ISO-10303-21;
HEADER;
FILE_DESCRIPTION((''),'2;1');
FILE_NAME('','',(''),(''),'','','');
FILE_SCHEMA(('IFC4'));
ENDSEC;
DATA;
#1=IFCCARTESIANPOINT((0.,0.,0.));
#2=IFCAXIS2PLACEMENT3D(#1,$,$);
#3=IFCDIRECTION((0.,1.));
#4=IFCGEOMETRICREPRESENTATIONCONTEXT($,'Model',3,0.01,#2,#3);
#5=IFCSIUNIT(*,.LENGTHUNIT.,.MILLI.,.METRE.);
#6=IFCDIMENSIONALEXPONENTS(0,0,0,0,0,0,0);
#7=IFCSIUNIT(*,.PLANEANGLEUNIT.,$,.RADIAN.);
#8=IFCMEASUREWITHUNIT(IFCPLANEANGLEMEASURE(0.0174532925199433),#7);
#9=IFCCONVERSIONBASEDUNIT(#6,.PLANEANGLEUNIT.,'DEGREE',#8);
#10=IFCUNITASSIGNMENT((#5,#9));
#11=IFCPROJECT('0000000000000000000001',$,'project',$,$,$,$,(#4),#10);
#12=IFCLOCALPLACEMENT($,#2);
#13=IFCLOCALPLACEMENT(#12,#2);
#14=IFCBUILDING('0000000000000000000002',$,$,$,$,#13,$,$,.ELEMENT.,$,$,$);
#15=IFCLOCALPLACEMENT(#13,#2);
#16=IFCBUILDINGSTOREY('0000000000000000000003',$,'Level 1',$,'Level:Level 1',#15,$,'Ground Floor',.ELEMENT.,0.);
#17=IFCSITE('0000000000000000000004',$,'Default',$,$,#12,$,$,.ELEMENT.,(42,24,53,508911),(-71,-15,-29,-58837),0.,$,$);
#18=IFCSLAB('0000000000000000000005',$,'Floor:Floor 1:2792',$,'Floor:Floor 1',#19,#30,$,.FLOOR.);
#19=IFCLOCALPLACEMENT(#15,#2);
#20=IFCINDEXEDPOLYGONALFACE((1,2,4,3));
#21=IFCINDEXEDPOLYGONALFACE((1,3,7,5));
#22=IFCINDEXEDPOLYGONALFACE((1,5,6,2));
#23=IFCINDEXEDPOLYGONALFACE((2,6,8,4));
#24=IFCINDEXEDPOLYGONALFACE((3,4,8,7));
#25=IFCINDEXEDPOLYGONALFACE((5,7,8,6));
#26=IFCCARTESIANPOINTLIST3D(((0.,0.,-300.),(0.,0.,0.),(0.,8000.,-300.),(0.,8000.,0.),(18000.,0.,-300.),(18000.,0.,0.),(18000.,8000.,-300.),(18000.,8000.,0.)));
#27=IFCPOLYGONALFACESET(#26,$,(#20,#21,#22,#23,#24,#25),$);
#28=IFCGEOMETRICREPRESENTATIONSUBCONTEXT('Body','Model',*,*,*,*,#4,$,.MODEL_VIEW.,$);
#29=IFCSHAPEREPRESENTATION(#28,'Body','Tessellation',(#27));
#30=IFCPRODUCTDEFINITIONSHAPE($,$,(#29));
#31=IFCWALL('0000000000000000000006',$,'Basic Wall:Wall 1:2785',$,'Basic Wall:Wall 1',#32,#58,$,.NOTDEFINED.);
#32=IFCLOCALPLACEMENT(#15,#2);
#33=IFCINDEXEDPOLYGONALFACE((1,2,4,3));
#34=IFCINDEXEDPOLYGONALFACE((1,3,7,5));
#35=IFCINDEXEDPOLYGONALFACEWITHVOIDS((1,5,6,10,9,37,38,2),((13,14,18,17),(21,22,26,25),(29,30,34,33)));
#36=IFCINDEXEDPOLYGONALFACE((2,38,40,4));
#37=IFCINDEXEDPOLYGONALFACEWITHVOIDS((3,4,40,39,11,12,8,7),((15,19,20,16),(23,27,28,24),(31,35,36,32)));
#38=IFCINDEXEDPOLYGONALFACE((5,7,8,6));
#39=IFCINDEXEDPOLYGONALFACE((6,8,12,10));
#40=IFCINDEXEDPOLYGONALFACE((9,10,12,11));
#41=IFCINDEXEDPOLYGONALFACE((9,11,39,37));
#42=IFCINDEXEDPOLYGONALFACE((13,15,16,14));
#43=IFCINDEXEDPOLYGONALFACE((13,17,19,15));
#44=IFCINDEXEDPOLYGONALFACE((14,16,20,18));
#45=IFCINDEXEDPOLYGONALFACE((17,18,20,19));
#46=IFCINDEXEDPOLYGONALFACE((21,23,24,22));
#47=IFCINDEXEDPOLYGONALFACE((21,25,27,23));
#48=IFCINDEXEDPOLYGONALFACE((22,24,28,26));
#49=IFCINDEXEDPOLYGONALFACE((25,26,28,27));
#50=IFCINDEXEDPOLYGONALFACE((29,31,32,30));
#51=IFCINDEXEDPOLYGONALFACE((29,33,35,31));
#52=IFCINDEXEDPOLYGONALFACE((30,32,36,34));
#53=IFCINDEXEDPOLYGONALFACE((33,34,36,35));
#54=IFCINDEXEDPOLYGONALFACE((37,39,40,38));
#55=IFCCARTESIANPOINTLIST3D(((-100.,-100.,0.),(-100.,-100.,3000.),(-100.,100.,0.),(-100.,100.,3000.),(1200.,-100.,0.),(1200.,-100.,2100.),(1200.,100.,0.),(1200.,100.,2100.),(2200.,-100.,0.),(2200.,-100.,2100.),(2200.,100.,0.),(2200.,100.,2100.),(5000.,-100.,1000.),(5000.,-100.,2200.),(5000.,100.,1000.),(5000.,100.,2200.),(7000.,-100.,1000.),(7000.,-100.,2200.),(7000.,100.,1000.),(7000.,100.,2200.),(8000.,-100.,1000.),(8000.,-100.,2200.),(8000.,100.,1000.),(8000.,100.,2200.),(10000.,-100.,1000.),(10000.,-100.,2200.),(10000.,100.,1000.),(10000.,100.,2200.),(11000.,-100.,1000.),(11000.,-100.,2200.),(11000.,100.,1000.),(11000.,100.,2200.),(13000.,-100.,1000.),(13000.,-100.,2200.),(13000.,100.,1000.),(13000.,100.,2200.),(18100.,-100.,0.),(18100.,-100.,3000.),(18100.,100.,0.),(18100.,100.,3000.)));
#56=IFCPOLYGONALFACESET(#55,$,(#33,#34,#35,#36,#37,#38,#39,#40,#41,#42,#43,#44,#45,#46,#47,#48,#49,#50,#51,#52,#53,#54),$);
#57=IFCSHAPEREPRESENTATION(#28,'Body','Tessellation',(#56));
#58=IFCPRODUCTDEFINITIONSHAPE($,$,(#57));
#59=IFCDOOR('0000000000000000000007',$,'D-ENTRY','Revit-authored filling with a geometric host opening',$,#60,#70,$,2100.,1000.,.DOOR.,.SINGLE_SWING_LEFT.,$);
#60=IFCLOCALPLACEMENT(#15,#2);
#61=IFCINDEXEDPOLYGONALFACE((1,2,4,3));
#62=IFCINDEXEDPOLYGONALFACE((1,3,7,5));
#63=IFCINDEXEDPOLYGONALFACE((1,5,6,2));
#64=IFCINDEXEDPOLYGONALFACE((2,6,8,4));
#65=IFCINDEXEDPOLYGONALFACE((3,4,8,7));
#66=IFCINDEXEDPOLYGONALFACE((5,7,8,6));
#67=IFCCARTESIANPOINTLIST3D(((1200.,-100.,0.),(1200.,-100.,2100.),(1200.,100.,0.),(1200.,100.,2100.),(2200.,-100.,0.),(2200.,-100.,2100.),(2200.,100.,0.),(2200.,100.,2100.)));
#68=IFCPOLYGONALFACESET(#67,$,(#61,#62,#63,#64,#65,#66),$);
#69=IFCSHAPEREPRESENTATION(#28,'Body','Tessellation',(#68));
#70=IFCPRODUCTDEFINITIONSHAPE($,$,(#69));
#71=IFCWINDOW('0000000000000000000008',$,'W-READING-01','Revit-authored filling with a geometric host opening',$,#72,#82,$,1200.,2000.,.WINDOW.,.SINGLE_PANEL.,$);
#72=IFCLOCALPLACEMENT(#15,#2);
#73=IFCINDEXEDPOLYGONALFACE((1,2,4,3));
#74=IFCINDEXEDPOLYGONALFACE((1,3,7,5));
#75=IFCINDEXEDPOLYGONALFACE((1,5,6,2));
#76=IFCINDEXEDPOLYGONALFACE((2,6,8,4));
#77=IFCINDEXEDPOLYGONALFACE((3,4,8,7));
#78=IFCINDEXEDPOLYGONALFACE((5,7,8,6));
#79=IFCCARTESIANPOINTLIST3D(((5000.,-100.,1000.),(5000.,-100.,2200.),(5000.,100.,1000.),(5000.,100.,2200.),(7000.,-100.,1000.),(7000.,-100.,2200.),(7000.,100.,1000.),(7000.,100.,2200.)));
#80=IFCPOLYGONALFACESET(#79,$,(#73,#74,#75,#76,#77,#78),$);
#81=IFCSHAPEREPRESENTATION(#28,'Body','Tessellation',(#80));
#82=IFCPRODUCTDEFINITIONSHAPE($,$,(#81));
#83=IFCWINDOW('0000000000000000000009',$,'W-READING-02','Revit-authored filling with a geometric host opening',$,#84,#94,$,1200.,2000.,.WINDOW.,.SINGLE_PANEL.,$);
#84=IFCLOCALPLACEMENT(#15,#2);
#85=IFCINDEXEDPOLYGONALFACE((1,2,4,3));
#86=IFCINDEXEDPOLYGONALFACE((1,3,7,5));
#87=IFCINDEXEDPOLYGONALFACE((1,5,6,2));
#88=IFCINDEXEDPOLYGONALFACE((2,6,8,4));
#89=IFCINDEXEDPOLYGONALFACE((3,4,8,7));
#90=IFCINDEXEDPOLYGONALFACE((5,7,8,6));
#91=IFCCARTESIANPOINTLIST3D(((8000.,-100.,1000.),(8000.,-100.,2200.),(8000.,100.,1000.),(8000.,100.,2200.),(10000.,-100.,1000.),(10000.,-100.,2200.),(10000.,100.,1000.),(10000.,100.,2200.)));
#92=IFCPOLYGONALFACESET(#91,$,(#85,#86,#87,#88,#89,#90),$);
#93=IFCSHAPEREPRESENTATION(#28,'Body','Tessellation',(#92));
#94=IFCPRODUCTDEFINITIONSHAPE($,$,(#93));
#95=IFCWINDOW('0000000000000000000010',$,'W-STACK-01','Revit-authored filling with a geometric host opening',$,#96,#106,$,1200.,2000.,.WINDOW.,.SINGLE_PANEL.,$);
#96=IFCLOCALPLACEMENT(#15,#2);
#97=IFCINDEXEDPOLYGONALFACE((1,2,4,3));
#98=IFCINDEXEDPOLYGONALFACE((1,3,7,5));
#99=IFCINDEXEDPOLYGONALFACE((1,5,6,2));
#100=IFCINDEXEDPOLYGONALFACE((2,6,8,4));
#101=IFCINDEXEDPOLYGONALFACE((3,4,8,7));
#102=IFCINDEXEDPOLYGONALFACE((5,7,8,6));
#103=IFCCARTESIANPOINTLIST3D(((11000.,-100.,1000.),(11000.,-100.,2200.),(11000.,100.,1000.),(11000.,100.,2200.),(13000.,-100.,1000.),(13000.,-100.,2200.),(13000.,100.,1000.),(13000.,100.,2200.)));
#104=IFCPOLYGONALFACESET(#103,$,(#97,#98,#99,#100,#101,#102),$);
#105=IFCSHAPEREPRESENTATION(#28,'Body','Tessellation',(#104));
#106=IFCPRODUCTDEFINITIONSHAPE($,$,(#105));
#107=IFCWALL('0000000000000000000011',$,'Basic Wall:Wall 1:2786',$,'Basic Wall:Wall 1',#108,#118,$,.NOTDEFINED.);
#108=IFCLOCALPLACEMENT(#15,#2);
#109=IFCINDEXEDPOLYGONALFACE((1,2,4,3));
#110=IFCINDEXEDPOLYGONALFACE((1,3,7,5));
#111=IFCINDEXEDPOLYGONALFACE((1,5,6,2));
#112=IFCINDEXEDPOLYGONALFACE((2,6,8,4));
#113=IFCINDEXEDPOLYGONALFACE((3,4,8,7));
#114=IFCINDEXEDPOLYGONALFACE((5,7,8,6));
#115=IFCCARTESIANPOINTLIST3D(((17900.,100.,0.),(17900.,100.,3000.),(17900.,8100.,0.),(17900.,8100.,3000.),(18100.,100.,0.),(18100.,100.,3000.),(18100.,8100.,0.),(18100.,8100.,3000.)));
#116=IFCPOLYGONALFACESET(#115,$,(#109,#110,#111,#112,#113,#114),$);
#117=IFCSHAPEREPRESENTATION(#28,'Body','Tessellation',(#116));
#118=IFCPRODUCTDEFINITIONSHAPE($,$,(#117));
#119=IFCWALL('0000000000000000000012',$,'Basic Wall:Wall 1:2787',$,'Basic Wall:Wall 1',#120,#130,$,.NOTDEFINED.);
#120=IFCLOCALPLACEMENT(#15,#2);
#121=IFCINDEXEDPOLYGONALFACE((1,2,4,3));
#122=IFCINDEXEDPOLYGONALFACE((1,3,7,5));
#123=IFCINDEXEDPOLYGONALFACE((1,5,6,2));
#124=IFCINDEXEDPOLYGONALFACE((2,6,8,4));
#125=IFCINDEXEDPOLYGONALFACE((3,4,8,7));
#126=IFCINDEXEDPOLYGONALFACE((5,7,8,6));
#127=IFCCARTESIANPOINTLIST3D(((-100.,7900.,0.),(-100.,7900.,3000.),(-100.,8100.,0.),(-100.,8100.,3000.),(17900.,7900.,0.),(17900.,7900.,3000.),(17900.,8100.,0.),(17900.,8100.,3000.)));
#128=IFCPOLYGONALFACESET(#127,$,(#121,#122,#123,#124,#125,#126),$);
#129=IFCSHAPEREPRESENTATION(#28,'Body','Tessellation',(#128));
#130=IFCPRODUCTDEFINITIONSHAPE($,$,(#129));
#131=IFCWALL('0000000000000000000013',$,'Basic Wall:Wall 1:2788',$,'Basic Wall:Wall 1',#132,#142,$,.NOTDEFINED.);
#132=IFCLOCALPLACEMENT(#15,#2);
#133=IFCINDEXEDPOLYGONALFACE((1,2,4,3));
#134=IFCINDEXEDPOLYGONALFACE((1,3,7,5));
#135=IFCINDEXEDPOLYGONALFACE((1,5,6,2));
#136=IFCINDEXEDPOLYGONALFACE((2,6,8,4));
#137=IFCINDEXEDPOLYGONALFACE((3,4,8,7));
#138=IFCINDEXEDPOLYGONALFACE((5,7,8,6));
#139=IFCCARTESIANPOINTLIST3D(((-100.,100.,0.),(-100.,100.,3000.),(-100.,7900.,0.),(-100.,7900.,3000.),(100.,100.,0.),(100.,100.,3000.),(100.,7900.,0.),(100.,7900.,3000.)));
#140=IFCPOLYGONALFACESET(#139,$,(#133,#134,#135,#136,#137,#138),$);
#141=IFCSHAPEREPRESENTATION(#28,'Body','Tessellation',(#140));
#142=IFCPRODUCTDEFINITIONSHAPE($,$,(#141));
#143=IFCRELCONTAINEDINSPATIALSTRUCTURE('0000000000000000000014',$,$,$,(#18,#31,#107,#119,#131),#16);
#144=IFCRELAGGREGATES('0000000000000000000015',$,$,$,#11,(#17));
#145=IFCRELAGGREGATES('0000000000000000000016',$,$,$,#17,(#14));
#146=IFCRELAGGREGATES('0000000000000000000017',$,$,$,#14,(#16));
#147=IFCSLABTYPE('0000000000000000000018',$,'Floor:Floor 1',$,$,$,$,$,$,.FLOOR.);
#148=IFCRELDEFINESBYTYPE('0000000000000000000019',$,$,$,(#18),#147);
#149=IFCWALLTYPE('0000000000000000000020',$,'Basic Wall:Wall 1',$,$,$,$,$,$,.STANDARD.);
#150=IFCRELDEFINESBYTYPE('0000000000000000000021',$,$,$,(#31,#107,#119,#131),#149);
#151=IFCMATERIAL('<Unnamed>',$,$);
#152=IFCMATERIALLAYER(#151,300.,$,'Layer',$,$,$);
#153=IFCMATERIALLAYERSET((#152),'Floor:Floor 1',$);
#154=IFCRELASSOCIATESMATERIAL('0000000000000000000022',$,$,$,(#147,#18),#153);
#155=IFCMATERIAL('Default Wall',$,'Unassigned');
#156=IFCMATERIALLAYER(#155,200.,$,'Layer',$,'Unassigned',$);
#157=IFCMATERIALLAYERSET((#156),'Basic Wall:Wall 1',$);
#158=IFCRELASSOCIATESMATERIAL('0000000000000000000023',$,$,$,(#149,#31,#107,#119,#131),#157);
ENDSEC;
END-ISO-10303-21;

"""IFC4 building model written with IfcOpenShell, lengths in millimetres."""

from ifc_helpers import new_model, entity, si_unit, converted_unit, direction, frame, frame_2d, origin, origin_2d, origin_2d_with_axis, place, context, subcontext, project, spatial, rectangle, extrude, material, layer, layer_set, layer_usage, type_object, element, fill, save


model = new_model("IFC4")

# Units and contexts
model_context = context("Model", 3, precision=0.01, world=origin(), true_north=direction((0.0, 1.0)))
body_context = subcontext(model_context, "Body", "Model", "MODEL_VIEW")
ifc_project = project(units=[si_unit("LENGTHUNIT", "METRE", prefix="MILLI"), converted_unit("PLANEANGLEUNIT", "DEGREE", entity("IfcPlaneAngleMeasure", 0.0174532925199433), si_unit("PLANEANGLEUNIT", "RADIAN"), dimensions=[0, 0, 0, 0, 0, 0, 0])], contexts=[model_context])

# Site, building, storey
site_placement = place(None, origin())
site = spatial("IfcSite", under=ifc_project, at=site_placement, Name="Default", CompositionType="ELEMENT", RefLatitude=(42, 24, 53, 508911), RefLongitude=(-71, -15, -29, -58837), RefElevation=0.0)
building_placement = place(site_placement, origin())
building = spatial("IfcBuilding", under=site, at=building_placement, CompositionType="ELEMENT")
storey_placement = place(building_placement, origin())
storey = spatial("IfcBuildingStorey", under=building, at=storey_placement, Name="Level 1", ObjectType="Level:Level 1", LongName="Ground Floor", CompositionType="ELEMENT", Elevation=0.0)

# Slab
ifc_material_1 = material(Name="<Unnamed>")
ifc_layer_1 = layer(ifc_material_1, 300.0, Name="Layer")
ifc_layer_set_1 = layer_set([ifc_layer_1], Name="Floor:Floor 1")
ifc_layer_usage_1 = layer_usage(ifc_layer_set_1, "AXIS3", "POSITIVE", 0.0)
slab_type = type_object("IfcSlabType", Name="Floor:Floor 1", PredefinedType="FLOOR", material=ifc_layer_set_1)
slab_placement = place(storey_placement, origin())
element("IfcSlab", 1, at=slab_placement, inside=storey, type_object=slab_type, material=ifc_layer_usage_1, Name="Floor:Floor 1:2792", ObjectType="Floor:Floor 1", PredefinedType="FLOOR", context=body_context, shape_type="SweptSolid", body=[
    extrude(rectangle(XDim=8000.0, YDim=18000.0, at=origin_2d_with_axis()), frame((9000.0, 4000.0, 0.0), z_axis=(0.0, 0.0, -1.0), x_axis=(0.0, 1.0, 0.0)), (0.0, 0.0, 1.0), 300.0),
])

# Wall, openings, door, windows
ifc_material_2 = material(Name="Default Wall", Category="Unassigned")
ifc_layer_2 = layer(ifc_material_2, 200.0, Name="Layer", Category="Unassigned")
ifc_layer_set_2 = layer_set([ifc_layer_2], Name="Basic Wall:Wall 1")
ifc_layer_usage_2 = layer_usage(ifc_layer_set_2, "AXIS2", "NEGATIVE", 100.0)
wall_type = type_object("IfcWallType", Name="Basic Wall:Wall 1", PredefinedType="STANDARD", material=ifc_layer_set_2)
wall_1_placement = place(storey_placement, frame((-100.0, 0.0, 0.0)))
wall_1 = element("IfcWall", 2, at=wall_1_placement, inside=storey, type_object=wall_type, material=ifc_layer_usage_2, Name="Basic Wall:Wall 1:2785", ObjectType="Basic Wall:Wall 1", PredefinedType="NOTDEFINED", context=body_context, shape_type="SweptSolid", body=[
    extrude(rectangle(XDim=18200.0, YDim=200.0, at=frame_2d((9100.0, 0.0), x_axis=(-1.0, 0.0))), origin(), (0.0, 0.0, 1.0), 3000.0),
])
opening_1_placement = place(storey_placement, frame((1200.0, -100.0, 0.0)))
opening_1 = element("IfcOpeningElement", 3, at=opening_1_placement, cuts=wall_1, PredefinedType="OPENING", context=body_context, shape_type="SweptSolid", body=[
    extrude(rectangle(XDim=1000.0, YDim=200.0, at=origin_2d()), frame((500.0, 100.0, 0.0)), (0.0, 0.0, 1.0), 2100.0),
])
opening_2_placement = place(storey_placement, frame((5000.0, -100.0, 1000.0)))
opening_2 = element("IfcOpeningElement", 4, at=opening_2_placement, cuts=wall_1, PredefinedType="OPENING", context=body_context, shape_type="SweptSolid", body=[
    extrude(rectangle(XDim=2000.0, YDim=200.0, at=origin_2d()), frame((1000.0, 100.0, 0.0)), (0.0, 0.0, 1.0), 1200.0),
])
opening_3_placement = place(storey_placement, frame((8000.0, -100.0, 1000.0)))
opening_3 = element("IfcOpeningElement", 5, at=opening_3_placement, cuts=wall_1, PredefinedType="OPENING", context=body_context, shape_type="SweptSolid", body=[
    extrude(rectangle(XDim=2000.0, YDim=200.0, at=origin_2d()), frame((1000.0, 100.0, 0.0)), (0.0, 0.0, 1.0), 1200.0),
])
opening_4_placement = place(storey_placement, frame((11000.0, -100.0, 1000.0)))
opening_4 = element("IfcOpeningElement", 6, at=opening_4_placement, cuts=wall_1, PredefinedType="OPENING", context=body_context, shape_type="SweptSolid", body=[
    extrude(rectangle(XDim=2000.0, YDim=200.0, at=origin_2d()), frame((1000.0, 100.0, 0.0)), (0.0, 0.0, 1.0), 1200.0),
])
door_1_placement = place(storey_placement, frame((1200.0, -100.0, 0.0)))
door_1 = element("IfcDoor", 7, at=door_1_placement, Name="D-ENTRY", Description="Revit-authored filling with a geometric host opening", OperationType="SINGLE_SWING_LEFT", OverallHeight=2100.0, OverallWidth=1000.0, PredefinedType="DOOR", context=body_context, shape_type="SweptSolid", body=[
    extrude(rectangle(XDim=1000.0, YDim=200.0, at=origin_2d()), frame((500.0, 100.0, 0.0)), (0.0, 0.0, 1.0), 2100.0),
])
fill(opening_1, door_1)
window_1_placement = place(storey_placement, frame((5000.0, -100.0, 1000.0)))
window_1 = element("IfcWindow", 8, at=window_1_placement, Name="W-READING-01", Description="Revit-authored filling with a geometric host opening", OverallHeight=1200.0, OverallWidth=2000.0, PartitioningType="SINGLE_PANEL", PredefinedType="WINDOW", context=body_context, shape_type="SweptSolid", body=[
    extrude(rectangle(XDim=2000.0, YDim=200.0, at=origin_2d()), frame((1000.0, 100.0, 0.0)), (0.0, 0.0, 1.0), 1200.0),
])
fill(opening_2, window_1)
window_2_placement = place(storey_placement, frame((8000.0, -100.0, 1000.0)))
window_2 = element("IfcWindow", 9, at=window_2_placement, Name="W-READING-02", Description="Revit-authored filling with a geometric host opening", OverallHeight=1200.0, OverallWidth=2000.0, PartitioningType="SINGLE_PANEL", PredefinedType="WINDOW", context=body_context, shape_type="SweptSolid", body=[
    extrude(rectangle(XDim=2000.0, YDim=200.0, at=origin_2d()), frame((1000.0, 100.0, 0.0)), (0.0, 0.0, 1.0), 1200.0),
])
fill(opening_3, window_2)
window_3_placement = place(storey_placement, frame((11000.0, -100.0, 1000.0)))
window_3 = element("IfcWindow", 10, at=window_3_placement, Name="W-STACK-01", Description="Revit-authored filling with a geometric host opening", OverallHeight=1200.0, OverallWidth=2000.0, PartitioningType="SINGLE_PANEL", PredefinedType="WINDOW", context=body_context, shape_type="SweptSolid", body=[
    extrude(rectangle(XDim=2000.0, YDim=200.0, at=origin_2d()), frame((1000.0, 100.0, 0.0)), (0.0, 0.0, 1.0), 1200.0),
])
fill(opening_4, window_3)

# Walls
ifc_layer_usage_3 = layer_usage(ifc_layer_set_2, "AXIS2", "NEGATIVE", 100.0)
wall_2_placement = place(storey_placement, frame((18000.0, 100.0, 0.0), z_axis=(0.0, 0.0, 1.0), x_axis=(0.0, 1.0, 0.0)))
element("IfcWall", 11, at=wall_2_placement, inside=storey, type_object=wall_type, material=ifc_layer_usage_3, Name="Basic Wall:Wall 1:2786", ObjectType="Basic Wall:Wall 1", PredefinedType="NOTDEFINED", context=body_context, shape_type="SweptSolid", body=[
    extrude(rectangle(XDim=8000.0, YDim=200.0, at=frame_2d((4000.0, 0.0), x_axis=(-1.0, 0.0))), origin(), (0.0, 0.0, 1.0), 3000.0),
])
ifc_layer_usage_4 = layer_usage(ifc_layer_set_2, "AXIS2", "NEGATIVE", 100.0)
wall_3_placement = place(storey_placement, frame((17900.0, 8000.0, 0.0), z_axis=(0.0, 0.0, 1.0), x_axis=(-1.0, 0.0, 0.0)))
element("IfcWall", 12, at=wall_3_placement, inside=storey, type_object=wall_type, material=ifc_layer_usage_4, Name="Basic Wall:Wall 1:2787", ObjectType="Basic Wall:Wall 1", PredefinedType="NOTDEFINED", context=body_context, shape_type="SweptSolid", body=[
    extrude(rectangle(XDim=18000.0, YDim=200.0, at=frame_2d((9000.0, 0.0), x_axis=(-1.0, 0.0))), origin(), (0.0, 0.0, 1.0), 3000.0),
])
ifc_layer_usage_5 = layer_usage(ifc_layer_set_2, "AXIS2", "NEGATIVE", 100.0)
wall_4_placement = place(storey_placement, frame((0.0, 7900.0, 0.0), z_axis=(0.0, 0.0, 1.0), x_axis=(0.0, -1.0, 0.0)))
element("IfcWall", 13, at=wall_4_placement, inside=storey, type_object=wall_type, material=ifc_layer_usage_5, Name="Basic Wall:Wall 1:2788", ObjectType="Basic Wall:Wall 1", PredefinedType="NOTDEFINED", context=body_context, shape_type="SweptSolid", body=[
    extrude(rectangle(XDim=7800.0, YDim=200.0, at=frame_2d((3900.0, 0.0), x_axis=(-1.0, 0.0))), origin(), (0.0, 0.0, 1.0), 3000.0),
])

save(model, "model.ifc")
